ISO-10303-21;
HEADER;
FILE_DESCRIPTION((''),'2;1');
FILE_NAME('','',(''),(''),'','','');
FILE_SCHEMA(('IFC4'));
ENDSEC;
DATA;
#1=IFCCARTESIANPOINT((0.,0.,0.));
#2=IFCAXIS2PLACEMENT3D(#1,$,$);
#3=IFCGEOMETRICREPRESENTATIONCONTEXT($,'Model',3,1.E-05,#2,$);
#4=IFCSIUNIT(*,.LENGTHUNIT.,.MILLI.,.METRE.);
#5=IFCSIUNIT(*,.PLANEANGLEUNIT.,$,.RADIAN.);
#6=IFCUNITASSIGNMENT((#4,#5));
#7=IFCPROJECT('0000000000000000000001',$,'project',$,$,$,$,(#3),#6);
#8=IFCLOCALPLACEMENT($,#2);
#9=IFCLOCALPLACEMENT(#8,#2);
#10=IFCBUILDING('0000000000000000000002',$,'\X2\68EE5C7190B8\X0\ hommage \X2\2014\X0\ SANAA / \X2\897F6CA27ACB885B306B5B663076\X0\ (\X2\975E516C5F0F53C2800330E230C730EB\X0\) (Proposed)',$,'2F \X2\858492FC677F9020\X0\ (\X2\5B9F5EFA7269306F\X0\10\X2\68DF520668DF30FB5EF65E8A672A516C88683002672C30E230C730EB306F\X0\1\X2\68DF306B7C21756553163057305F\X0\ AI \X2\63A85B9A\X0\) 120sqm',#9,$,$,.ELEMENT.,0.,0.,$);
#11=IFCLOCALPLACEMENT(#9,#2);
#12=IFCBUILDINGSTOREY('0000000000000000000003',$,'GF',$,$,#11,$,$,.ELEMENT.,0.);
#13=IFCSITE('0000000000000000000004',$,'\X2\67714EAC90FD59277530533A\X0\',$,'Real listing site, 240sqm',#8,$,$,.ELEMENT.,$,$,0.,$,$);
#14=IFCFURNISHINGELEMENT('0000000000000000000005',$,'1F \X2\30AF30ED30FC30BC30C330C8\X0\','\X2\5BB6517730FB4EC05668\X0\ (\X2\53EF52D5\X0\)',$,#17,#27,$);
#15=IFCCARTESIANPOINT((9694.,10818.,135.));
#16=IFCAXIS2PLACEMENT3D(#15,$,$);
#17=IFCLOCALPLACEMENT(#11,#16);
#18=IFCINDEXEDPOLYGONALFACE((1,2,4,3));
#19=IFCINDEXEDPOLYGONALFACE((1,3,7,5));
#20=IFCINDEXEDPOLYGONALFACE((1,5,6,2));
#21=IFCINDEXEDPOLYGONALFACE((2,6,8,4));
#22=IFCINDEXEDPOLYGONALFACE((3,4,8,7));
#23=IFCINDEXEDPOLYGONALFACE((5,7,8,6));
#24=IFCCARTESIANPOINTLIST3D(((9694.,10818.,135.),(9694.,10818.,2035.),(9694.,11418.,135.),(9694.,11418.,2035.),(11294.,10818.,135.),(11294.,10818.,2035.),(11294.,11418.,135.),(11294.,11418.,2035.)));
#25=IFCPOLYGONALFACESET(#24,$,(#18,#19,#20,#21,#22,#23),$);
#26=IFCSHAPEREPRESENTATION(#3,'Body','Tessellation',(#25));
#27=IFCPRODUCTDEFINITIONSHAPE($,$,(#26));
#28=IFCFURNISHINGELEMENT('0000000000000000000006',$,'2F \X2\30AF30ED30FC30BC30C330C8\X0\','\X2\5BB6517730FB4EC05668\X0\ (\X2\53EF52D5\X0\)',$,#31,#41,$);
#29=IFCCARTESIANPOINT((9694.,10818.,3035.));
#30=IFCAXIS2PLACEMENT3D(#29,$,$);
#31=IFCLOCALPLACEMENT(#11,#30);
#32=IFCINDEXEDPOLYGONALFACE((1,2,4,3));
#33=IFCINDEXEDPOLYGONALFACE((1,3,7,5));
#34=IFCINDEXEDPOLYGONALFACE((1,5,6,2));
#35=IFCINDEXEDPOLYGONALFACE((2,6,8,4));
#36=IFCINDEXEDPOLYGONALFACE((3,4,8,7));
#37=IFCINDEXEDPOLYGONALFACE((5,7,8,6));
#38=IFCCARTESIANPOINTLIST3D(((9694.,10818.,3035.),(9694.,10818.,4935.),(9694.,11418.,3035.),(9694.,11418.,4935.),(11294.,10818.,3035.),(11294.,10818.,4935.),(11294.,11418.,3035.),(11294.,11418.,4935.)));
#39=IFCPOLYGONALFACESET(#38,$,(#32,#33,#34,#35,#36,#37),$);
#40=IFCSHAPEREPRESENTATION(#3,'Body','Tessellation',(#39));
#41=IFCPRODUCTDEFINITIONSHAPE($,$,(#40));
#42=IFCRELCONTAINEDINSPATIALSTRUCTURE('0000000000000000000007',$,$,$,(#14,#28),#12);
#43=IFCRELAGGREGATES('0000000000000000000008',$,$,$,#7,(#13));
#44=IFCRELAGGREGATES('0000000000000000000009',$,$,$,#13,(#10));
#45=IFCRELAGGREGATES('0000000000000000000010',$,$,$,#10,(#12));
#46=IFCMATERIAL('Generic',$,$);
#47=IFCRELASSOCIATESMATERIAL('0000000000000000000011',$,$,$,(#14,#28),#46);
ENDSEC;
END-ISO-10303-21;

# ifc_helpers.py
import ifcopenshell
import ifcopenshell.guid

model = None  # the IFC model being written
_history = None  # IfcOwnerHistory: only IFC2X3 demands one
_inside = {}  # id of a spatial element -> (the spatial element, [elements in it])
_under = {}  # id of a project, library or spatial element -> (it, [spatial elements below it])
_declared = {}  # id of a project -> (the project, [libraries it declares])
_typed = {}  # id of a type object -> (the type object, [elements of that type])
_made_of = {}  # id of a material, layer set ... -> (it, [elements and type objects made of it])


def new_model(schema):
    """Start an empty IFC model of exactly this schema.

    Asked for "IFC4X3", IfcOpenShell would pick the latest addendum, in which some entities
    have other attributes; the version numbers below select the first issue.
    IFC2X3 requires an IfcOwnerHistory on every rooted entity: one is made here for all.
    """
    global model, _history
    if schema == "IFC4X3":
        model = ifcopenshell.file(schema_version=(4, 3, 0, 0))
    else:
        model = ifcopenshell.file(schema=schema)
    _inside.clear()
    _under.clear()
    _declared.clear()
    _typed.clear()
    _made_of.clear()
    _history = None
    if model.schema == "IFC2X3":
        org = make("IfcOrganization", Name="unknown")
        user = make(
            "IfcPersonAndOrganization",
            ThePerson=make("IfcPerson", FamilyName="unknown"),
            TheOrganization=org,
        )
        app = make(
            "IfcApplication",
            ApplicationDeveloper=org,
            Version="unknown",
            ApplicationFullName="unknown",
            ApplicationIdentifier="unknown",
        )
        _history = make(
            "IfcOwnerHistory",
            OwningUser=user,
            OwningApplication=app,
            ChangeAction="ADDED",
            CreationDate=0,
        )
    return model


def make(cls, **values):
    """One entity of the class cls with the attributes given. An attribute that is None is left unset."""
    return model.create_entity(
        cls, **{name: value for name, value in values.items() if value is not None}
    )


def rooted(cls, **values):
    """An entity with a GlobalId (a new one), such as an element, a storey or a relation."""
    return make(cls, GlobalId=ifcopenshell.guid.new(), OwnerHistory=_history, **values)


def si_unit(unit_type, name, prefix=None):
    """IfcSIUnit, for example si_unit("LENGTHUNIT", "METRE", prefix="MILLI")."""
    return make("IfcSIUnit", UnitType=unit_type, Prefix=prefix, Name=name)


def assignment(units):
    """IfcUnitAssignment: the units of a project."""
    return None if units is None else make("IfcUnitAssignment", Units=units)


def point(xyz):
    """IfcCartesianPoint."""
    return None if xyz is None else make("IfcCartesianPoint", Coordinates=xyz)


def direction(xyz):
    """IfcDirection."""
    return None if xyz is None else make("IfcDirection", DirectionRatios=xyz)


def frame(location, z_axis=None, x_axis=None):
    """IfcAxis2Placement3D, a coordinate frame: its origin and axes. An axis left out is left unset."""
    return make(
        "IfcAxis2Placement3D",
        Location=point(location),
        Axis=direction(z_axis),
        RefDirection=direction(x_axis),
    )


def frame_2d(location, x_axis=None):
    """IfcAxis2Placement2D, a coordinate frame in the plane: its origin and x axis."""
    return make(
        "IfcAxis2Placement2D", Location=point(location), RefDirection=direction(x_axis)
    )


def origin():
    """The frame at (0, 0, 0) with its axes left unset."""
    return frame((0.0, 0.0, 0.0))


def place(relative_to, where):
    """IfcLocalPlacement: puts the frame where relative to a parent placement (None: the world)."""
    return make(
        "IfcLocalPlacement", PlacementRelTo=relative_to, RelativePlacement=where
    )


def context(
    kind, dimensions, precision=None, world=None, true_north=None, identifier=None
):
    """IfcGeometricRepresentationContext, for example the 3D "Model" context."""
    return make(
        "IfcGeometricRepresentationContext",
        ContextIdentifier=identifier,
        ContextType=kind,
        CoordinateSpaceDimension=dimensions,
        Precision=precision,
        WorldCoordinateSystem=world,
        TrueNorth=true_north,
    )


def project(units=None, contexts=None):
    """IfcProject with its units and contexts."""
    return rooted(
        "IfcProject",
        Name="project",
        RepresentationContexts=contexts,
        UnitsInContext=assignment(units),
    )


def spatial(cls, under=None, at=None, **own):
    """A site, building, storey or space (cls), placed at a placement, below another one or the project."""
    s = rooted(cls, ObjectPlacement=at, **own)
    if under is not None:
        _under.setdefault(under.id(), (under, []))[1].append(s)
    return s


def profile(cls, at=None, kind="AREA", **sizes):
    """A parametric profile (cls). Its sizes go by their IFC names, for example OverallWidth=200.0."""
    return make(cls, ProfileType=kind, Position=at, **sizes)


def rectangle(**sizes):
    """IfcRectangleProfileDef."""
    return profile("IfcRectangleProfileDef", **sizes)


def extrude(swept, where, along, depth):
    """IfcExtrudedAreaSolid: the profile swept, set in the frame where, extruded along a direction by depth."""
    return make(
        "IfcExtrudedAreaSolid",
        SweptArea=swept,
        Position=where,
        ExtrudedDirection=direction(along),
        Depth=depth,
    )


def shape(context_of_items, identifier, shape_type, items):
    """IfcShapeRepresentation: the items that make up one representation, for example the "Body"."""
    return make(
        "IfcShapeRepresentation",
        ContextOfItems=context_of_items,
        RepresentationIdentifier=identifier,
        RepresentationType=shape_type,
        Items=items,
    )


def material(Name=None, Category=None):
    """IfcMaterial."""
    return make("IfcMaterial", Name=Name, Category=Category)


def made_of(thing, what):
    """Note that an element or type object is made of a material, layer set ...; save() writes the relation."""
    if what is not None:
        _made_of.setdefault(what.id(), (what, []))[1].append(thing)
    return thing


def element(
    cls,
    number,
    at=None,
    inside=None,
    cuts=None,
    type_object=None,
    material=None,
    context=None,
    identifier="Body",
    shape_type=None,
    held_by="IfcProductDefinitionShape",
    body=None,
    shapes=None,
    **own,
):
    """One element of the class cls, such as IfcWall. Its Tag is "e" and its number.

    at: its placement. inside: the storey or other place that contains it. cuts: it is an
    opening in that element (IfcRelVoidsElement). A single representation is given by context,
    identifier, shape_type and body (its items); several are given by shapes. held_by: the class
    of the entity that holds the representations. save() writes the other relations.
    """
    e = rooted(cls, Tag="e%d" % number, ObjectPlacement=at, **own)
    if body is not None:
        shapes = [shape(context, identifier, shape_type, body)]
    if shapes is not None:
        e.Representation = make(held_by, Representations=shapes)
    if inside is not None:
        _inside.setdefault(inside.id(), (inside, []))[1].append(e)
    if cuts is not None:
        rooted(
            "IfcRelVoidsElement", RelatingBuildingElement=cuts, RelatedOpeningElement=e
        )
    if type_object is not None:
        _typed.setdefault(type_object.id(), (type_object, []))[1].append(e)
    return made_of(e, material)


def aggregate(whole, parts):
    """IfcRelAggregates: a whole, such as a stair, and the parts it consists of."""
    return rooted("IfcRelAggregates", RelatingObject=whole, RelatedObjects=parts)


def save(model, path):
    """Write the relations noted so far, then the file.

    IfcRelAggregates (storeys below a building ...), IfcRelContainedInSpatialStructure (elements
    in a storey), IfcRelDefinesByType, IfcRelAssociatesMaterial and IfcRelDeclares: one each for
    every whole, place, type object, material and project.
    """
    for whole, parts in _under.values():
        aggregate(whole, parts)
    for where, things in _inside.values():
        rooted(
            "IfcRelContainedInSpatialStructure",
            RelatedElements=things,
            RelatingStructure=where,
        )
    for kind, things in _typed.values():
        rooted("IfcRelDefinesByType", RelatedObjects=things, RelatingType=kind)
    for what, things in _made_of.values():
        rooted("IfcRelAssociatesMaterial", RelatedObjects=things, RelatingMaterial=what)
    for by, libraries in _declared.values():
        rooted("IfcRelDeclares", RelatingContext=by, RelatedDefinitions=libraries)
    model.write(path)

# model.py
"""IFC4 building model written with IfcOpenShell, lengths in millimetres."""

from ifc_helpers import new_model, si_unit, frame, frame_2d, origin, place, context, project, spatial, rectangle, extrude, material, element, save


model = new_model("IFC4")

# Units and contexts
model_context = context("Model", 3, precision=1e-05, world=origin())
ifc_project = project(units=[si_unit("LENGTHUNIT", "METRE", prefix="MILLI"), si_unit("PLANEANGLEUNIT", "RADIAN")], contexts=[model_context])

# Site, building, storey
site_placement = place(None, origin())
site = spatial("IfcSite", under=ifc_project, at=site_placement, Name="東京都大田区", ObjectType="Real listing site, 240sqm", CompositionType="ELEMENT", RefElevation=0.0)
building_placement = place(site_placement, origin())
building = spatial("IfcBuilding", under=site, at=building_placement, Name="森山邸 hommage — SANAA / 西沢立衛に学ぶ (非公式参考モデル) (Proposed)", ObjectType="2F 薄鋼板造 (実建物は10棟分棟・延床未公表。本モデルは1棟に簡略化した AI 推定) 120sqm", CompositionType="ELEMENT", ElevationOfRefHeight=0.0, ElevationOfTerrain=0.0)
storey_placement = place(building_placement, origin())
storey = spatial("IfcBuildingStorey", under=building, at=storey_placement, Name="GF", CompositionType="ELEMENT", Elevation=0.0)

# Shared definitions
ifc_material_1 = material(Name="Generic")

# Furnishing elements
furnishing_1_placement = place(storey_placement, frame((9694.0, 10818.0, 135.0)))
element("IfcFurnishingElement", 1, at=furnishing_1_placement, inside=storey, material=ifc_material_1, Name="1F クローゼット", Description="家具・什器 (可動)", context=model_context, shape_type="SweptSolid", body=[
    extrude(rectangle(XDim=1600.0, YDim=600.0, at=frame_2d((800.0, 300.0))), frame((9694.0, 10818.0, 135.0)), (0.0, 0.0, 1.0), 1900.0),
])
furnishing_2_placement = place(storey_placement, frame((9694.0, 10818.0, 3035.0)))
element("IfcFurnishingElement", 2, at=furnishing_2_placement, inside=storey, material=ifc_material_1, Name="2F クローゼット", Description="家具・什器 (可動)", context=model_context, shape_type="SweptSolid", body=[
    extrude(rectangle(XDim=1600.0, YDim=600.0, at=frame_2d((800.0, 300.0))), frame((9694.0, 10818.0, 3035.0)), (0.0, 0.0, 1.0), 1900.0),
])

save(model, "model.ifc")
